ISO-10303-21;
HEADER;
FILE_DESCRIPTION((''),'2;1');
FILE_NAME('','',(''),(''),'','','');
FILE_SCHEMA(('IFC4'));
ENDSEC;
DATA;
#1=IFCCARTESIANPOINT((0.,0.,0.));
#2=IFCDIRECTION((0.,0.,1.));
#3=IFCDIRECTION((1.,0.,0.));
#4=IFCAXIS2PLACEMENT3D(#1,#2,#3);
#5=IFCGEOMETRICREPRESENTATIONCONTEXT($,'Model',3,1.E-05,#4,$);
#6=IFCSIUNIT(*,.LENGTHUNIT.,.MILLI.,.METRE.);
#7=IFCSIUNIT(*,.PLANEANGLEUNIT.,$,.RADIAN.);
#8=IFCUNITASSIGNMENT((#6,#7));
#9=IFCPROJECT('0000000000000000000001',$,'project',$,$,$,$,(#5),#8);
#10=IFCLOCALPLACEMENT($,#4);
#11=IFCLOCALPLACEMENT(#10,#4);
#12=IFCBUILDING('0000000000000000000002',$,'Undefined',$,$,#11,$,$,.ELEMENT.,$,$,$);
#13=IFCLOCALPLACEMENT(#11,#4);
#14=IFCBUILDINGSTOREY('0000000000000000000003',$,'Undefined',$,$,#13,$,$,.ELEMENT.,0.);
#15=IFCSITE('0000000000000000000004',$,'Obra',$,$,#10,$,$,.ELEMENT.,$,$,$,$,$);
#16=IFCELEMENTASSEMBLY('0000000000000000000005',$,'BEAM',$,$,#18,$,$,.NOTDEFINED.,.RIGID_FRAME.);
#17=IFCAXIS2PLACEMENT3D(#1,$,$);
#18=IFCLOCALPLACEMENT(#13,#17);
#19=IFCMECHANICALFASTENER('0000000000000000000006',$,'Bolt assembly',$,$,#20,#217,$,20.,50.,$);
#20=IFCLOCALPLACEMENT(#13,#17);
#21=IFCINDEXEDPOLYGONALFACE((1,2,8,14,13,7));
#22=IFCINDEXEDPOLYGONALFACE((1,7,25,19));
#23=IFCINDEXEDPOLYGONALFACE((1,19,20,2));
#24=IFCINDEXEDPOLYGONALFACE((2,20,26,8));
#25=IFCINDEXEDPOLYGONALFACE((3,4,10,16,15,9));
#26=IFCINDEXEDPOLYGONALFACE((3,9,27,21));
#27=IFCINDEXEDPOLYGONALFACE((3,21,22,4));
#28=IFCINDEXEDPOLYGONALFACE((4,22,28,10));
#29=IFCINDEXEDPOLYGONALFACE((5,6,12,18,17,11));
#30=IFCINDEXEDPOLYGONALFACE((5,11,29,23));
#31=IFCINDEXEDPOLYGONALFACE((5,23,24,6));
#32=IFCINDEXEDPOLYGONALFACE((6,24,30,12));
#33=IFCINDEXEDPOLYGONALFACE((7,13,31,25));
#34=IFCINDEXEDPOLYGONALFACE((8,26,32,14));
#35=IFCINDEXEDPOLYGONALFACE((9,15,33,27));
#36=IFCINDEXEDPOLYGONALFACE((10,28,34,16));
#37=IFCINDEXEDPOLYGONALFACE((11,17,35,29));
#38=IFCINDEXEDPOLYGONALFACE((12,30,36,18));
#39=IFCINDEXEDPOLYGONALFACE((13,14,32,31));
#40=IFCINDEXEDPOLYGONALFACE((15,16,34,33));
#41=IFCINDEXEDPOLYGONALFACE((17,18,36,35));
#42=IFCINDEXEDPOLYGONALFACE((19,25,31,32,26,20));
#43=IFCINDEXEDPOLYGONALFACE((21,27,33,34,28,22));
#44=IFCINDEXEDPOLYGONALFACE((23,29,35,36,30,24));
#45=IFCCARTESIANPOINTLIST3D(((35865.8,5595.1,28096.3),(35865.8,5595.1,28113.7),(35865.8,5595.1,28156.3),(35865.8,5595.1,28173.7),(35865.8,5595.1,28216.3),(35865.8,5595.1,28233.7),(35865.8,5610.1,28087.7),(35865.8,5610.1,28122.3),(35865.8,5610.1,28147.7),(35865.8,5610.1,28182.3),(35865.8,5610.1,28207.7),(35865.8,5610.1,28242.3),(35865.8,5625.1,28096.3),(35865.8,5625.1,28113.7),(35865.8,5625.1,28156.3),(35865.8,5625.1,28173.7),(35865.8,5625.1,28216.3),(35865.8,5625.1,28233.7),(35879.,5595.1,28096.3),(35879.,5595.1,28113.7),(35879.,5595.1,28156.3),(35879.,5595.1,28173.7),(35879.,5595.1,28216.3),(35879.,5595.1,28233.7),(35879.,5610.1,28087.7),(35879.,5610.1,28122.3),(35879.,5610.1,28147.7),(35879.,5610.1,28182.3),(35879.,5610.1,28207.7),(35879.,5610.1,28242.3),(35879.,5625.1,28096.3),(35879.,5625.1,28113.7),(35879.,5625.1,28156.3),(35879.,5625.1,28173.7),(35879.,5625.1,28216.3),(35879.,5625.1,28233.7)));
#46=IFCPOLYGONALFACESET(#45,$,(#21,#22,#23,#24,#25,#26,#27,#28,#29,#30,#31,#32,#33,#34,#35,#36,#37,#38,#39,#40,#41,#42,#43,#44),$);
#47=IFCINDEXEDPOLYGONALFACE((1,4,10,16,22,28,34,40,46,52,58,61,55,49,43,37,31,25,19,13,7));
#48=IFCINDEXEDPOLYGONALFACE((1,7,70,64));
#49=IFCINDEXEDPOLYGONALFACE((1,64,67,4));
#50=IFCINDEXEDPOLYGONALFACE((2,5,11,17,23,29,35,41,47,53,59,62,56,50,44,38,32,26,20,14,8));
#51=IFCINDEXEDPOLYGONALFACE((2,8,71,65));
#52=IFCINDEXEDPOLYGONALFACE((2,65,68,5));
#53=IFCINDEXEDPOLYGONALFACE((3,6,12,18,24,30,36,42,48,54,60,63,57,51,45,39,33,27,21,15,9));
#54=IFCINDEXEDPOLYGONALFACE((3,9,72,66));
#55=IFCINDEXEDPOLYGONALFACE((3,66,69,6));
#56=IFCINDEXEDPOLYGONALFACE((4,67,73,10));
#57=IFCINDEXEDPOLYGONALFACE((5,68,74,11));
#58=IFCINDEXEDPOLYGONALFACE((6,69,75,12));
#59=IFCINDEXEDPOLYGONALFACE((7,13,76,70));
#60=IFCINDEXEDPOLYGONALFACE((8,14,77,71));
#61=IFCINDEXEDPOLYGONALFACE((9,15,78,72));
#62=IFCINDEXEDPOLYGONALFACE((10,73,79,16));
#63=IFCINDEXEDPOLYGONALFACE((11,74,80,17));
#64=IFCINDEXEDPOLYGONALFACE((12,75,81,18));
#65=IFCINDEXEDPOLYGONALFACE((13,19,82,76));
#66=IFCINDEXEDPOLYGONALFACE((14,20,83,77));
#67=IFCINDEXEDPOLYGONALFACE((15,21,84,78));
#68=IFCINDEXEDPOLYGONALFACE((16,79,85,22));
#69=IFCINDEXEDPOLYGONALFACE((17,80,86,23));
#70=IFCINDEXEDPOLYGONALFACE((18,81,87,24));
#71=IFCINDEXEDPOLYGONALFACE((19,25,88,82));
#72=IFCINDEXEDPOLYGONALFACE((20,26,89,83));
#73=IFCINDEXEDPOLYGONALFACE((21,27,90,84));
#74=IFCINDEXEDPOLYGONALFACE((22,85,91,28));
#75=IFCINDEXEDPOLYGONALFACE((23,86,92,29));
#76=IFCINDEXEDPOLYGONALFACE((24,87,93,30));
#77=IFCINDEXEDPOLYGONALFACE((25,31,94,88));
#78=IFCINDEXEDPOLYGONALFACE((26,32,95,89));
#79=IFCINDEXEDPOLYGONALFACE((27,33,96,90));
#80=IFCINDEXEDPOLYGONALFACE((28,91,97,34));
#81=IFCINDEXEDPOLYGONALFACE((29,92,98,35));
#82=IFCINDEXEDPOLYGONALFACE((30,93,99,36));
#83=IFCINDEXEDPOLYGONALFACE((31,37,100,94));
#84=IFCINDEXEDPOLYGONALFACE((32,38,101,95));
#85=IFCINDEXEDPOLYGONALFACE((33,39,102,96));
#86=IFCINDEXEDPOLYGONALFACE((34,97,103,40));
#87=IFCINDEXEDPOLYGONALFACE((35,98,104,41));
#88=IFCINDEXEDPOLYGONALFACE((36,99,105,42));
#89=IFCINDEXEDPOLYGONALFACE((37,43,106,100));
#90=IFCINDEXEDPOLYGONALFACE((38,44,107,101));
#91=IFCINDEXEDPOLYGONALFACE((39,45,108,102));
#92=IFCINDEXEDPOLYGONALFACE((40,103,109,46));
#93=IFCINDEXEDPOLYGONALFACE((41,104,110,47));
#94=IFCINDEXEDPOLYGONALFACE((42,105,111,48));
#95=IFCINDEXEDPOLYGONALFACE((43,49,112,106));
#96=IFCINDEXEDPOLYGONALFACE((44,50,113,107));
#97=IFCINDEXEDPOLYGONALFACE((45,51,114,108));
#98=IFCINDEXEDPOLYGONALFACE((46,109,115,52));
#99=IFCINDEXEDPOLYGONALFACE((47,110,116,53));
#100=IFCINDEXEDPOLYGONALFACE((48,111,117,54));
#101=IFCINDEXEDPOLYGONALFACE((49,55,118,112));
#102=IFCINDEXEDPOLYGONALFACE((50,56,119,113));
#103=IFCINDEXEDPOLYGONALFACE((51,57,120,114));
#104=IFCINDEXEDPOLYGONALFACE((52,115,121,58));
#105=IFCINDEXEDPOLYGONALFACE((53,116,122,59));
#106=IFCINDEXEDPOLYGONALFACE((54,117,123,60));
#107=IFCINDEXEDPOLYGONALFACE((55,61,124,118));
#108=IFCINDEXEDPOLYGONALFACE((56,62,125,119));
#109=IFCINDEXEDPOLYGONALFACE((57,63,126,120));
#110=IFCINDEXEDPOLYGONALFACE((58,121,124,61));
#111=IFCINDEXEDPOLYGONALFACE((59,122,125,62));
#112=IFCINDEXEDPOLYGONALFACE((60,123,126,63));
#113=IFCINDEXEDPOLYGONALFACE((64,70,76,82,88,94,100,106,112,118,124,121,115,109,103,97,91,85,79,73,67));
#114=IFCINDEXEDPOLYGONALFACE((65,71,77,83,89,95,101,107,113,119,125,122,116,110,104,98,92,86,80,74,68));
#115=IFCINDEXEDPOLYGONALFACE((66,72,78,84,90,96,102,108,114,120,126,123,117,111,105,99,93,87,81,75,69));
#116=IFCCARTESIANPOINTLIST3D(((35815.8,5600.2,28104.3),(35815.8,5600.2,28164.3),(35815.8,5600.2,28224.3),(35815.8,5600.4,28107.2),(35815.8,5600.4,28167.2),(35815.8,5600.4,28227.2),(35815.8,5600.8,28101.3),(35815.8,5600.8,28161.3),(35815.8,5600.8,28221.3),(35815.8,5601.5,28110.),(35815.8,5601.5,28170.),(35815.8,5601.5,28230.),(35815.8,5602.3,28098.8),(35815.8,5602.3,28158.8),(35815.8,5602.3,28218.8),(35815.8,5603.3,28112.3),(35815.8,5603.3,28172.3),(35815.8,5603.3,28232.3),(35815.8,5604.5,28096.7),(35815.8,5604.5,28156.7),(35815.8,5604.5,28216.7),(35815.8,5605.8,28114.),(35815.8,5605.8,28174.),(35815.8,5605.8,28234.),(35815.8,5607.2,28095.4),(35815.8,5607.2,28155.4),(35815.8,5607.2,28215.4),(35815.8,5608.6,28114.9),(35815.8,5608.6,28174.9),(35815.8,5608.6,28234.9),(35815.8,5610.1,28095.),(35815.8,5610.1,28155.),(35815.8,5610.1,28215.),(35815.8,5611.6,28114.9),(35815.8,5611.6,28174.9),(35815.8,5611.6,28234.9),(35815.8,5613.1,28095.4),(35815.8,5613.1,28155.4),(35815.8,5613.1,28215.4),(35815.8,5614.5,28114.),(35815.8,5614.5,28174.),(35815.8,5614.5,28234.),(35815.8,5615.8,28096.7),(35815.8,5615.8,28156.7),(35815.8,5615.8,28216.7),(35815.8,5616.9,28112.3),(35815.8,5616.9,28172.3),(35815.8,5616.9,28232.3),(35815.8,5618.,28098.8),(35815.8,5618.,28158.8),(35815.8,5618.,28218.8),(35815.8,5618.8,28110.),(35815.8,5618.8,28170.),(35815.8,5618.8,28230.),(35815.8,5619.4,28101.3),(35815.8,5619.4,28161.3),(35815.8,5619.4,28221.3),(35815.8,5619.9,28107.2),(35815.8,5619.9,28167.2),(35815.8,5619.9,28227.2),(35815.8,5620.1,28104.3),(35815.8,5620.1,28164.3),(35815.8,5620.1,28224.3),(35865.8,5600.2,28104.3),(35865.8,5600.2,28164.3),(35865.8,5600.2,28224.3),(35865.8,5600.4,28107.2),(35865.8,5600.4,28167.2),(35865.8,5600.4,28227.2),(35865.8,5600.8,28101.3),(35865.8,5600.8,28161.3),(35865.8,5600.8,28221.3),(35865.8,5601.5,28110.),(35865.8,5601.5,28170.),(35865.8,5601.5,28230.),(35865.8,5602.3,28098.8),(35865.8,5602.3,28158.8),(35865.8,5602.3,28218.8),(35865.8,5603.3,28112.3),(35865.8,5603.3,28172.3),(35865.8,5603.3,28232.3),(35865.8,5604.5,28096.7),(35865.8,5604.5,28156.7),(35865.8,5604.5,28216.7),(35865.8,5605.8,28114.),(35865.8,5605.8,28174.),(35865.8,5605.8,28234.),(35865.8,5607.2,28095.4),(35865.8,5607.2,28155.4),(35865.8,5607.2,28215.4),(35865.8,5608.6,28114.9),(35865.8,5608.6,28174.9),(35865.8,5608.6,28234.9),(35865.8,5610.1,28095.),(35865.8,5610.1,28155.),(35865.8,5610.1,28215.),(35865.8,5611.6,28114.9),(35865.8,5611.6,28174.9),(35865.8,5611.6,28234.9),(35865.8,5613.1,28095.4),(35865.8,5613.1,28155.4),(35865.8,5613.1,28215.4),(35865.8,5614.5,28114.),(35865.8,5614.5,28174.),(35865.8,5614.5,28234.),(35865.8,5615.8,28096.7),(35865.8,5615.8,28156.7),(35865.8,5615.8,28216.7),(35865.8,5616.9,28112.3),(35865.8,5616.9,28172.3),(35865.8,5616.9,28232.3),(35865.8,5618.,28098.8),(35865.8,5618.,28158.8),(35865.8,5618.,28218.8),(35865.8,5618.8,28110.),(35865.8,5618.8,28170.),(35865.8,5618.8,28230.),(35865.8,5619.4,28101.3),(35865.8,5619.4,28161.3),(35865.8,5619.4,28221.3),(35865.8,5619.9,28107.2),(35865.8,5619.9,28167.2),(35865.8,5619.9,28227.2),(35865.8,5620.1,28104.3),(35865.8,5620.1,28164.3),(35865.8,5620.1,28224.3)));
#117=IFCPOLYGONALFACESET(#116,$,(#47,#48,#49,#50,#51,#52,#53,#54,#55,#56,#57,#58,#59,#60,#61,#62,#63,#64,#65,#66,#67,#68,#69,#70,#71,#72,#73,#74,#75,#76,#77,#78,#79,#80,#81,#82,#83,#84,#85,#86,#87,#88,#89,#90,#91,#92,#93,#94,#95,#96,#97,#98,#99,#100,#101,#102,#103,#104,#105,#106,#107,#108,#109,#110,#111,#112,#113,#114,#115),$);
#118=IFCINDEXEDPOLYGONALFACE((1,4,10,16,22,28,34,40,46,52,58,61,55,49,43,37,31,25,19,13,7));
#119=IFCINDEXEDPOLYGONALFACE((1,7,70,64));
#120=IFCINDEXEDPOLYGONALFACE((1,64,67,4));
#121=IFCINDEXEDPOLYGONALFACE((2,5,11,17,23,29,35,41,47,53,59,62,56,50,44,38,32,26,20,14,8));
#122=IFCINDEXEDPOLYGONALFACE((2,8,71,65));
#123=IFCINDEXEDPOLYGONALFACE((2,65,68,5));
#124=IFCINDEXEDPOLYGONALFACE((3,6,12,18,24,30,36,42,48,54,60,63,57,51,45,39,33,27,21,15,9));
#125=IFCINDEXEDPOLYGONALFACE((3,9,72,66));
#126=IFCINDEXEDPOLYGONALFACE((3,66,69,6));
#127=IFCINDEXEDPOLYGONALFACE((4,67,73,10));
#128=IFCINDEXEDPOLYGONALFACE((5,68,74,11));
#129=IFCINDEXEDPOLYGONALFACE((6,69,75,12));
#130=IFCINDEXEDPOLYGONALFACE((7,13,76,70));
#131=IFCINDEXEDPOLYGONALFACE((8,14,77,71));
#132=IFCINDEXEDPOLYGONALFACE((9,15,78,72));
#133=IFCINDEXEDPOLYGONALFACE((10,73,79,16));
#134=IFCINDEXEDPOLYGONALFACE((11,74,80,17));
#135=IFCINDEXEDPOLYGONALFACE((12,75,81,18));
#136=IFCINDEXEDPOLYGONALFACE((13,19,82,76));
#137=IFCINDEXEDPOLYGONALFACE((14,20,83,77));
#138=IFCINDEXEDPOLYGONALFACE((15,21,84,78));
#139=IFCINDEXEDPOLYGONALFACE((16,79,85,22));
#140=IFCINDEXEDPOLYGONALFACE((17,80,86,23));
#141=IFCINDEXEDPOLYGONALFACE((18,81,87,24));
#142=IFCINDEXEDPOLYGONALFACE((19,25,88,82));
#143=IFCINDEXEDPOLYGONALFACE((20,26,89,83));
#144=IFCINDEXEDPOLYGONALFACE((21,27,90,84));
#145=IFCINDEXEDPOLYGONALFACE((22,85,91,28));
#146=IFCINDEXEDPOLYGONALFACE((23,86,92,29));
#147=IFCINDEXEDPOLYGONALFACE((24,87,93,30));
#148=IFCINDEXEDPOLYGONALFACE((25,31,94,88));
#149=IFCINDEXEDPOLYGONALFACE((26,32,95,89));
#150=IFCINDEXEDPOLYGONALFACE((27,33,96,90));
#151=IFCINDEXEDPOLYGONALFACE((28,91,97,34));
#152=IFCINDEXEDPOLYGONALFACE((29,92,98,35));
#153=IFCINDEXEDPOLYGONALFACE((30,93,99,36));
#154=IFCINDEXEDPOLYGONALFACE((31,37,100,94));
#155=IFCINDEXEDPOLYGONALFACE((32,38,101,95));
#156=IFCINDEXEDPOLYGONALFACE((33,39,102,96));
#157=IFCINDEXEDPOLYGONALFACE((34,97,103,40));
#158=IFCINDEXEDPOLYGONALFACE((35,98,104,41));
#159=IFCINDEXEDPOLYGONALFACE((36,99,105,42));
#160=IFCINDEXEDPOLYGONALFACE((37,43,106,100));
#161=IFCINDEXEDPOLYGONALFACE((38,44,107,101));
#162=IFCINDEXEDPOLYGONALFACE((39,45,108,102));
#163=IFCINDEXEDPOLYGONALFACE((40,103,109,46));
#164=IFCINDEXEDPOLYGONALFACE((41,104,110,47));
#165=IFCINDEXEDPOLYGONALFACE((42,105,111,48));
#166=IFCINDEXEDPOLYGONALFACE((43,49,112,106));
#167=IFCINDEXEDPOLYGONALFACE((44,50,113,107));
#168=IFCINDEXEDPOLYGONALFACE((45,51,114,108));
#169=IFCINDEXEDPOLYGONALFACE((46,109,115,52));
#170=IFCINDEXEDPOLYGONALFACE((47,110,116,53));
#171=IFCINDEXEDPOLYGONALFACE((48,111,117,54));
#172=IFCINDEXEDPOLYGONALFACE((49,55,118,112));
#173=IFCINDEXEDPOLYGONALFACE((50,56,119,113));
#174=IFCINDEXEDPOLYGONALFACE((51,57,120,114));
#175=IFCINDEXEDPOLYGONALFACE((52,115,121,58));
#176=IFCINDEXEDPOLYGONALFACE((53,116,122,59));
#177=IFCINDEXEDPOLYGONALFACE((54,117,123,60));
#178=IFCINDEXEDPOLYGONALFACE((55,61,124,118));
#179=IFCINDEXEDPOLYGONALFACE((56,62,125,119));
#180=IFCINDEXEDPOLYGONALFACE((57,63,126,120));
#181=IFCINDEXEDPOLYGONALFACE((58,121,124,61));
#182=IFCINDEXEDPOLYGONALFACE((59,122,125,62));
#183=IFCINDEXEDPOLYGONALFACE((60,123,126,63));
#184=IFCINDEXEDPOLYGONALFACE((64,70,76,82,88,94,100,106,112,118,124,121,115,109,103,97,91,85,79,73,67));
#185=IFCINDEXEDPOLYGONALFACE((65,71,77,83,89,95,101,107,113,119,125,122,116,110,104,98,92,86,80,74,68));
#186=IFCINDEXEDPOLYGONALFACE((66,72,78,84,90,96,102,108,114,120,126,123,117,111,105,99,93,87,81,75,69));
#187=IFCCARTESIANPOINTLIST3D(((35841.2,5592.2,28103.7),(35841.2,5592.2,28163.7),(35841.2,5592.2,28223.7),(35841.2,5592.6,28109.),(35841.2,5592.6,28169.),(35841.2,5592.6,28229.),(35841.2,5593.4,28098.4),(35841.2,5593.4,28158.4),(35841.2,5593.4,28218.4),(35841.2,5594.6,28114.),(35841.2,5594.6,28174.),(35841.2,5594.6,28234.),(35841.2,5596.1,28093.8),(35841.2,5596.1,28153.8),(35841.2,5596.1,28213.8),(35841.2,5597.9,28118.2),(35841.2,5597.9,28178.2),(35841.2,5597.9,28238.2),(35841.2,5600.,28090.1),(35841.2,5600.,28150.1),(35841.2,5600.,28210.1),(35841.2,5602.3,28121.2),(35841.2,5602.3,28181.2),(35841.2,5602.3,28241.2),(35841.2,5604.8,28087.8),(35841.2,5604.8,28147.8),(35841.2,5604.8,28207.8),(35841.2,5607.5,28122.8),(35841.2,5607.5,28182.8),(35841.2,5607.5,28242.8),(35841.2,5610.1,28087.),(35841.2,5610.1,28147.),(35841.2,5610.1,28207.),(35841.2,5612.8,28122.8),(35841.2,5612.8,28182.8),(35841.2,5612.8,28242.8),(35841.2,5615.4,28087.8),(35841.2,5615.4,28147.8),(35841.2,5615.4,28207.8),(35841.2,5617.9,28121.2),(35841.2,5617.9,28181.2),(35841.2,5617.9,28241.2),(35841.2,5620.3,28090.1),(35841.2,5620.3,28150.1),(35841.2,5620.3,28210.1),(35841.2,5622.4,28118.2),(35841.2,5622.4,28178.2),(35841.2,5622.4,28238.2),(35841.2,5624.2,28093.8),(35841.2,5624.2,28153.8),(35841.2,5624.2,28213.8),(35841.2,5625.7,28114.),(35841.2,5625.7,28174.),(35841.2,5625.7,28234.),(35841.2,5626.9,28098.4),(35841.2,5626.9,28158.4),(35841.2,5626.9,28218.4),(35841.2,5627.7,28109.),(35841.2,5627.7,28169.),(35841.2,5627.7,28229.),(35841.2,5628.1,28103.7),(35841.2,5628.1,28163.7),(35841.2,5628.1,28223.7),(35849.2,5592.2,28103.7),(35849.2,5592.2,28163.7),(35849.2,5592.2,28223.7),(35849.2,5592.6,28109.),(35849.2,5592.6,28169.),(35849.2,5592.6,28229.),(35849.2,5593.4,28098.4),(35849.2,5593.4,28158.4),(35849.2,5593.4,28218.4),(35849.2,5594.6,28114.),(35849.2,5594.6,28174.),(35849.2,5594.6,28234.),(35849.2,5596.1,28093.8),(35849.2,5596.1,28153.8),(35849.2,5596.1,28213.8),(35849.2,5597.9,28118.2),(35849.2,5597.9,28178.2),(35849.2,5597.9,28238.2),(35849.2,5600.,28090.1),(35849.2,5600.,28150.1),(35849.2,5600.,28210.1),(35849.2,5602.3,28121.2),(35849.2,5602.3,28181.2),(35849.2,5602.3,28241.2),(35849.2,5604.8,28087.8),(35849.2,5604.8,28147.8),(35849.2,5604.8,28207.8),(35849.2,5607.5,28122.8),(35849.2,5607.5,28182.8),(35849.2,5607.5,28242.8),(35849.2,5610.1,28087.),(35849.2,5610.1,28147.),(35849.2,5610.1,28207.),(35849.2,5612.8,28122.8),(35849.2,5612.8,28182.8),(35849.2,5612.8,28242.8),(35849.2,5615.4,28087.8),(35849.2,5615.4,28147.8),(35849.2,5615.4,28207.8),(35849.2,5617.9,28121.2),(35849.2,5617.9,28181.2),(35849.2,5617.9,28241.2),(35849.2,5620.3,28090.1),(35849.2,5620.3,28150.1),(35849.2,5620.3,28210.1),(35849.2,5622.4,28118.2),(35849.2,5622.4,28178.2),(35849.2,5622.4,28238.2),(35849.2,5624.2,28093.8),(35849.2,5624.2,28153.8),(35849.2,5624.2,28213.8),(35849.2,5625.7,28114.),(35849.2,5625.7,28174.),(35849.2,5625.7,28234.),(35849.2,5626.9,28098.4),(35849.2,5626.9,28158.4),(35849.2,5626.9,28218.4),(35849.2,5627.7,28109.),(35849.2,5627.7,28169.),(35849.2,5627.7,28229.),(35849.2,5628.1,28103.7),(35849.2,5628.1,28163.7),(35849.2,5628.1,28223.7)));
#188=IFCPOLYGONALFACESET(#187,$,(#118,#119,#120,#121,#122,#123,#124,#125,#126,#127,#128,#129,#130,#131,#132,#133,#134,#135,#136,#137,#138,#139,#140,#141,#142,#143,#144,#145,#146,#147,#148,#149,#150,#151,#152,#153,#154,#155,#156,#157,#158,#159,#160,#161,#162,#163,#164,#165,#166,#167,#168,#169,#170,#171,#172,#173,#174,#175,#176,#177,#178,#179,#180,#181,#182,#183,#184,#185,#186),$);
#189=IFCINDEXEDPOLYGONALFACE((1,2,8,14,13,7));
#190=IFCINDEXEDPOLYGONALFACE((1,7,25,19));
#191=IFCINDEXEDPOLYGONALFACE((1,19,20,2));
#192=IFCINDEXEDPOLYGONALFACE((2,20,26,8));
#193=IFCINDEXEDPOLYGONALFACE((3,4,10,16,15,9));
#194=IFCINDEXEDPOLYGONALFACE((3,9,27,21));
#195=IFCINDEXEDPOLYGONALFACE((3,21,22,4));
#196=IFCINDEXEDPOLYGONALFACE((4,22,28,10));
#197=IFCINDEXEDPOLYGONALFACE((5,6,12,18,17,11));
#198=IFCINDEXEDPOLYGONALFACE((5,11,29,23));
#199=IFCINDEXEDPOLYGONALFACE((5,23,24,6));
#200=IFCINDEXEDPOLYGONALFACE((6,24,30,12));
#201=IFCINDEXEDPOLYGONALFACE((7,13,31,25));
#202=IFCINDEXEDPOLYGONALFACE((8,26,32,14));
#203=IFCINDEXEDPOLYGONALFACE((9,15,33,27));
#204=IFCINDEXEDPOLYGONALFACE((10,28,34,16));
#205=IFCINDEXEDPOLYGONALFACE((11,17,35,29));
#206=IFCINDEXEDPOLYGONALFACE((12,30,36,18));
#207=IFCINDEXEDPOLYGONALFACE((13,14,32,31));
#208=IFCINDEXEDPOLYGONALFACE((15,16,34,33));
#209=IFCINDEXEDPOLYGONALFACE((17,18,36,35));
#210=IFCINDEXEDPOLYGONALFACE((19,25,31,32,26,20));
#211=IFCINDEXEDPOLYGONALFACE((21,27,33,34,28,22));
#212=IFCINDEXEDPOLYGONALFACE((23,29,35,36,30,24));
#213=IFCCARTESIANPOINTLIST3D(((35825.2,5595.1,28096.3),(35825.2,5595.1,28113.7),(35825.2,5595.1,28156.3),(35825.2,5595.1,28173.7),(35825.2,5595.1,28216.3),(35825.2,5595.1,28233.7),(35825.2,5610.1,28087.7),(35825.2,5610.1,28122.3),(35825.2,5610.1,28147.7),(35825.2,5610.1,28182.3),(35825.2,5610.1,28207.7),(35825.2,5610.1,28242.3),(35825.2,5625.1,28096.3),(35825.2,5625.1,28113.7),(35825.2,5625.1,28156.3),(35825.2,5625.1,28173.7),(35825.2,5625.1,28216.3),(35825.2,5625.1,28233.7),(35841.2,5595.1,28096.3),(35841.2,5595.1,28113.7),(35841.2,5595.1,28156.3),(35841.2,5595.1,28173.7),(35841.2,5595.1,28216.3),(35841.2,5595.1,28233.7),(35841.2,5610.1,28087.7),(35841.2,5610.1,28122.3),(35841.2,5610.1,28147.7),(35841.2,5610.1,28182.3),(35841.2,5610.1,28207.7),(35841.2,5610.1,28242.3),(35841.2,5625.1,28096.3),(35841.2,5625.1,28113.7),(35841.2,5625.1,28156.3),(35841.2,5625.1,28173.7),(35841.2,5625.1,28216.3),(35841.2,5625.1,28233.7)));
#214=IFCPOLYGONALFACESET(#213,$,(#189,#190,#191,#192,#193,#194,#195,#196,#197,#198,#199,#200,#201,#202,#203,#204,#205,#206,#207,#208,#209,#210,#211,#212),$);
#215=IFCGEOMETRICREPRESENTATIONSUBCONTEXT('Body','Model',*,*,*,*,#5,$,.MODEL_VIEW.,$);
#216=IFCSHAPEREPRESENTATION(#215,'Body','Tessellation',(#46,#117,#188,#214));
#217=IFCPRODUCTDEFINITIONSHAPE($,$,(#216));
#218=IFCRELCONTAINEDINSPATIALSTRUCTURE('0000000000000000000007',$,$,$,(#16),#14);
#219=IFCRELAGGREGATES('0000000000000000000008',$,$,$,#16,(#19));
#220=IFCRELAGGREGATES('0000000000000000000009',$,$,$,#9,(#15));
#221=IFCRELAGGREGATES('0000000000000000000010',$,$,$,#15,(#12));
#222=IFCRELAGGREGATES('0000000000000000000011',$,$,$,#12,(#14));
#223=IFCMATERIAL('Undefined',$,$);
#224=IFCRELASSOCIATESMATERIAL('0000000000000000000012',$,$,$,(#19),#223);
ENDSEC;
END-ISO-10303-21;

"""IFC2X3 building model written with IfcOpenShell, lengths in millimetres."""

from ifc_helpers import new_model, si_unit, frame, origin_with_axes, origin_2d_with_axis, place, context, subcontext, project, spatial, polyline, circle, outline, extrude, source, transform, mapped, material, element, aggregate, save


model = new_model("IFC2X3")

# Units and contexts
model_context = context("Model", 3, precision=1e-05, world=origin_with_axes())
body_context = subcontext(model_context, "Body", "Model", "MODEL_VIEW")
ifc_project = project(units=[si_unit("LENGTHUNIT", "METRE", prefix="MILLI"), si_unit("PLANEANGLEUNIT", "RADIAN")], contexts=[model_context])

# Site, building, storey
site_placement = place(None, origin_with_axes())
site = spatial("IfcSite", under=ifc_project, at=site_placement, Name="Obra", CompositionType="ELEMENT")
building_placement = place(site_placement, origin_with_axes())
building = spatial("IfcBuilding", under=site, at=building_placement, Name="Undefined", CompositionType="ELEMENT")
storey_placement = place(building_placement, origin_with_axes())
storey = spatial("IfcBuildingStorey", under=building, at=storey_placement, Name="Undefined", CompositionType="ELEMENT", Elevation=0.0)

# Shared definitions
ifc_material_1 = material(Name="Undefined")

# Element assembly, mechanical fastener
assembly_1_placement = place(storey_placement, origin_with_axes())
assembly_1 = element("IfcElementAssembly", 1, at=assembly_1_placement, inside=storey, Name="BEAM", AssemblyPlace="NOTDEFINED", PredefinedType="RIGID_FRAME")
shared_shape_1 = source(origin_with_axes(), body_context, "Body", "SweptSolid", [
    extrude(outline(polyline([(17.3, 0.0), (8.7, 15.0), (-8.7, 15.0), (-17.3, 0.0), (-8.7, -15.0), (8.7, -15.0), (17.3, 0.0)])), frame((0.0, -26.5, 0.0), z_axis=(0.0, 1.0, 0.0), x_axis=(1.0, 0.0, 0.0)), (0.0, 0.0, 1.0), 13.2),
    extrude(circle(Radius=10.0, at=origin_2d_with_axis()), frame((0.0, -13.3, 0.0), z_axis=(0.0, 1.0, 0.0), x_axis=(1.0, 0.0, 0.0)), (0.0, 0.0, 1.0), 50.0),
    extrude(circle(Radius=18.0, at=origin_2d_with_axis()), frame((0.0, 3.3, 0.0), z_axis=(0.0, 1.0, 0.0), x_axis=(1.0, 0.0, 0.0)), (0.0, 0.0, 1.0), 8.0),
    extrude(outline(polyline([(17.3, 0.0), (8.7, 15.0), (-8.7, 15.0), (-17.3, 0.0), (-8.7, -15.0), (8.7, -15.0), (17.3, 0.0)])), frame((0.0, 11.3, 0.0), z_axis=(0.0, 1.0, 0.0), x_axis=(1.0, 0.0, 0.0)), (0.0, 0.0, 1.0), 16.0),
])
mechanical_fastener_1_placement = place(assembly_1_placement, frame((35852.5, 5560.1, 28265.0), z_axis=(0.0, 1.0, 0.0), x_axis=(0.0, 0.0, -1.0)))
mechanical_fastener_1 = element("IfcMechanicalFastener", 2, at=mechanical_fastener_1_placement, material=ifc_material_1, Name="Bolt assembly", NominalDiameter=20.0, NominalLength=50.0, context=body_context, shape_type="MappedRepresentation", body=[
    mapped(shared_shape_1, transform((40.0, 0.0, 50.0))),
    mapped(shared_shape_1, transform((100.0, 0.0, 50.0))),
    mapped(shared_shape_1, transform((160.0, 0.0, 50.0))),
])
aggregate(assembly_1, [mechanical_fastener_1])

save(model, "model.ifc")
